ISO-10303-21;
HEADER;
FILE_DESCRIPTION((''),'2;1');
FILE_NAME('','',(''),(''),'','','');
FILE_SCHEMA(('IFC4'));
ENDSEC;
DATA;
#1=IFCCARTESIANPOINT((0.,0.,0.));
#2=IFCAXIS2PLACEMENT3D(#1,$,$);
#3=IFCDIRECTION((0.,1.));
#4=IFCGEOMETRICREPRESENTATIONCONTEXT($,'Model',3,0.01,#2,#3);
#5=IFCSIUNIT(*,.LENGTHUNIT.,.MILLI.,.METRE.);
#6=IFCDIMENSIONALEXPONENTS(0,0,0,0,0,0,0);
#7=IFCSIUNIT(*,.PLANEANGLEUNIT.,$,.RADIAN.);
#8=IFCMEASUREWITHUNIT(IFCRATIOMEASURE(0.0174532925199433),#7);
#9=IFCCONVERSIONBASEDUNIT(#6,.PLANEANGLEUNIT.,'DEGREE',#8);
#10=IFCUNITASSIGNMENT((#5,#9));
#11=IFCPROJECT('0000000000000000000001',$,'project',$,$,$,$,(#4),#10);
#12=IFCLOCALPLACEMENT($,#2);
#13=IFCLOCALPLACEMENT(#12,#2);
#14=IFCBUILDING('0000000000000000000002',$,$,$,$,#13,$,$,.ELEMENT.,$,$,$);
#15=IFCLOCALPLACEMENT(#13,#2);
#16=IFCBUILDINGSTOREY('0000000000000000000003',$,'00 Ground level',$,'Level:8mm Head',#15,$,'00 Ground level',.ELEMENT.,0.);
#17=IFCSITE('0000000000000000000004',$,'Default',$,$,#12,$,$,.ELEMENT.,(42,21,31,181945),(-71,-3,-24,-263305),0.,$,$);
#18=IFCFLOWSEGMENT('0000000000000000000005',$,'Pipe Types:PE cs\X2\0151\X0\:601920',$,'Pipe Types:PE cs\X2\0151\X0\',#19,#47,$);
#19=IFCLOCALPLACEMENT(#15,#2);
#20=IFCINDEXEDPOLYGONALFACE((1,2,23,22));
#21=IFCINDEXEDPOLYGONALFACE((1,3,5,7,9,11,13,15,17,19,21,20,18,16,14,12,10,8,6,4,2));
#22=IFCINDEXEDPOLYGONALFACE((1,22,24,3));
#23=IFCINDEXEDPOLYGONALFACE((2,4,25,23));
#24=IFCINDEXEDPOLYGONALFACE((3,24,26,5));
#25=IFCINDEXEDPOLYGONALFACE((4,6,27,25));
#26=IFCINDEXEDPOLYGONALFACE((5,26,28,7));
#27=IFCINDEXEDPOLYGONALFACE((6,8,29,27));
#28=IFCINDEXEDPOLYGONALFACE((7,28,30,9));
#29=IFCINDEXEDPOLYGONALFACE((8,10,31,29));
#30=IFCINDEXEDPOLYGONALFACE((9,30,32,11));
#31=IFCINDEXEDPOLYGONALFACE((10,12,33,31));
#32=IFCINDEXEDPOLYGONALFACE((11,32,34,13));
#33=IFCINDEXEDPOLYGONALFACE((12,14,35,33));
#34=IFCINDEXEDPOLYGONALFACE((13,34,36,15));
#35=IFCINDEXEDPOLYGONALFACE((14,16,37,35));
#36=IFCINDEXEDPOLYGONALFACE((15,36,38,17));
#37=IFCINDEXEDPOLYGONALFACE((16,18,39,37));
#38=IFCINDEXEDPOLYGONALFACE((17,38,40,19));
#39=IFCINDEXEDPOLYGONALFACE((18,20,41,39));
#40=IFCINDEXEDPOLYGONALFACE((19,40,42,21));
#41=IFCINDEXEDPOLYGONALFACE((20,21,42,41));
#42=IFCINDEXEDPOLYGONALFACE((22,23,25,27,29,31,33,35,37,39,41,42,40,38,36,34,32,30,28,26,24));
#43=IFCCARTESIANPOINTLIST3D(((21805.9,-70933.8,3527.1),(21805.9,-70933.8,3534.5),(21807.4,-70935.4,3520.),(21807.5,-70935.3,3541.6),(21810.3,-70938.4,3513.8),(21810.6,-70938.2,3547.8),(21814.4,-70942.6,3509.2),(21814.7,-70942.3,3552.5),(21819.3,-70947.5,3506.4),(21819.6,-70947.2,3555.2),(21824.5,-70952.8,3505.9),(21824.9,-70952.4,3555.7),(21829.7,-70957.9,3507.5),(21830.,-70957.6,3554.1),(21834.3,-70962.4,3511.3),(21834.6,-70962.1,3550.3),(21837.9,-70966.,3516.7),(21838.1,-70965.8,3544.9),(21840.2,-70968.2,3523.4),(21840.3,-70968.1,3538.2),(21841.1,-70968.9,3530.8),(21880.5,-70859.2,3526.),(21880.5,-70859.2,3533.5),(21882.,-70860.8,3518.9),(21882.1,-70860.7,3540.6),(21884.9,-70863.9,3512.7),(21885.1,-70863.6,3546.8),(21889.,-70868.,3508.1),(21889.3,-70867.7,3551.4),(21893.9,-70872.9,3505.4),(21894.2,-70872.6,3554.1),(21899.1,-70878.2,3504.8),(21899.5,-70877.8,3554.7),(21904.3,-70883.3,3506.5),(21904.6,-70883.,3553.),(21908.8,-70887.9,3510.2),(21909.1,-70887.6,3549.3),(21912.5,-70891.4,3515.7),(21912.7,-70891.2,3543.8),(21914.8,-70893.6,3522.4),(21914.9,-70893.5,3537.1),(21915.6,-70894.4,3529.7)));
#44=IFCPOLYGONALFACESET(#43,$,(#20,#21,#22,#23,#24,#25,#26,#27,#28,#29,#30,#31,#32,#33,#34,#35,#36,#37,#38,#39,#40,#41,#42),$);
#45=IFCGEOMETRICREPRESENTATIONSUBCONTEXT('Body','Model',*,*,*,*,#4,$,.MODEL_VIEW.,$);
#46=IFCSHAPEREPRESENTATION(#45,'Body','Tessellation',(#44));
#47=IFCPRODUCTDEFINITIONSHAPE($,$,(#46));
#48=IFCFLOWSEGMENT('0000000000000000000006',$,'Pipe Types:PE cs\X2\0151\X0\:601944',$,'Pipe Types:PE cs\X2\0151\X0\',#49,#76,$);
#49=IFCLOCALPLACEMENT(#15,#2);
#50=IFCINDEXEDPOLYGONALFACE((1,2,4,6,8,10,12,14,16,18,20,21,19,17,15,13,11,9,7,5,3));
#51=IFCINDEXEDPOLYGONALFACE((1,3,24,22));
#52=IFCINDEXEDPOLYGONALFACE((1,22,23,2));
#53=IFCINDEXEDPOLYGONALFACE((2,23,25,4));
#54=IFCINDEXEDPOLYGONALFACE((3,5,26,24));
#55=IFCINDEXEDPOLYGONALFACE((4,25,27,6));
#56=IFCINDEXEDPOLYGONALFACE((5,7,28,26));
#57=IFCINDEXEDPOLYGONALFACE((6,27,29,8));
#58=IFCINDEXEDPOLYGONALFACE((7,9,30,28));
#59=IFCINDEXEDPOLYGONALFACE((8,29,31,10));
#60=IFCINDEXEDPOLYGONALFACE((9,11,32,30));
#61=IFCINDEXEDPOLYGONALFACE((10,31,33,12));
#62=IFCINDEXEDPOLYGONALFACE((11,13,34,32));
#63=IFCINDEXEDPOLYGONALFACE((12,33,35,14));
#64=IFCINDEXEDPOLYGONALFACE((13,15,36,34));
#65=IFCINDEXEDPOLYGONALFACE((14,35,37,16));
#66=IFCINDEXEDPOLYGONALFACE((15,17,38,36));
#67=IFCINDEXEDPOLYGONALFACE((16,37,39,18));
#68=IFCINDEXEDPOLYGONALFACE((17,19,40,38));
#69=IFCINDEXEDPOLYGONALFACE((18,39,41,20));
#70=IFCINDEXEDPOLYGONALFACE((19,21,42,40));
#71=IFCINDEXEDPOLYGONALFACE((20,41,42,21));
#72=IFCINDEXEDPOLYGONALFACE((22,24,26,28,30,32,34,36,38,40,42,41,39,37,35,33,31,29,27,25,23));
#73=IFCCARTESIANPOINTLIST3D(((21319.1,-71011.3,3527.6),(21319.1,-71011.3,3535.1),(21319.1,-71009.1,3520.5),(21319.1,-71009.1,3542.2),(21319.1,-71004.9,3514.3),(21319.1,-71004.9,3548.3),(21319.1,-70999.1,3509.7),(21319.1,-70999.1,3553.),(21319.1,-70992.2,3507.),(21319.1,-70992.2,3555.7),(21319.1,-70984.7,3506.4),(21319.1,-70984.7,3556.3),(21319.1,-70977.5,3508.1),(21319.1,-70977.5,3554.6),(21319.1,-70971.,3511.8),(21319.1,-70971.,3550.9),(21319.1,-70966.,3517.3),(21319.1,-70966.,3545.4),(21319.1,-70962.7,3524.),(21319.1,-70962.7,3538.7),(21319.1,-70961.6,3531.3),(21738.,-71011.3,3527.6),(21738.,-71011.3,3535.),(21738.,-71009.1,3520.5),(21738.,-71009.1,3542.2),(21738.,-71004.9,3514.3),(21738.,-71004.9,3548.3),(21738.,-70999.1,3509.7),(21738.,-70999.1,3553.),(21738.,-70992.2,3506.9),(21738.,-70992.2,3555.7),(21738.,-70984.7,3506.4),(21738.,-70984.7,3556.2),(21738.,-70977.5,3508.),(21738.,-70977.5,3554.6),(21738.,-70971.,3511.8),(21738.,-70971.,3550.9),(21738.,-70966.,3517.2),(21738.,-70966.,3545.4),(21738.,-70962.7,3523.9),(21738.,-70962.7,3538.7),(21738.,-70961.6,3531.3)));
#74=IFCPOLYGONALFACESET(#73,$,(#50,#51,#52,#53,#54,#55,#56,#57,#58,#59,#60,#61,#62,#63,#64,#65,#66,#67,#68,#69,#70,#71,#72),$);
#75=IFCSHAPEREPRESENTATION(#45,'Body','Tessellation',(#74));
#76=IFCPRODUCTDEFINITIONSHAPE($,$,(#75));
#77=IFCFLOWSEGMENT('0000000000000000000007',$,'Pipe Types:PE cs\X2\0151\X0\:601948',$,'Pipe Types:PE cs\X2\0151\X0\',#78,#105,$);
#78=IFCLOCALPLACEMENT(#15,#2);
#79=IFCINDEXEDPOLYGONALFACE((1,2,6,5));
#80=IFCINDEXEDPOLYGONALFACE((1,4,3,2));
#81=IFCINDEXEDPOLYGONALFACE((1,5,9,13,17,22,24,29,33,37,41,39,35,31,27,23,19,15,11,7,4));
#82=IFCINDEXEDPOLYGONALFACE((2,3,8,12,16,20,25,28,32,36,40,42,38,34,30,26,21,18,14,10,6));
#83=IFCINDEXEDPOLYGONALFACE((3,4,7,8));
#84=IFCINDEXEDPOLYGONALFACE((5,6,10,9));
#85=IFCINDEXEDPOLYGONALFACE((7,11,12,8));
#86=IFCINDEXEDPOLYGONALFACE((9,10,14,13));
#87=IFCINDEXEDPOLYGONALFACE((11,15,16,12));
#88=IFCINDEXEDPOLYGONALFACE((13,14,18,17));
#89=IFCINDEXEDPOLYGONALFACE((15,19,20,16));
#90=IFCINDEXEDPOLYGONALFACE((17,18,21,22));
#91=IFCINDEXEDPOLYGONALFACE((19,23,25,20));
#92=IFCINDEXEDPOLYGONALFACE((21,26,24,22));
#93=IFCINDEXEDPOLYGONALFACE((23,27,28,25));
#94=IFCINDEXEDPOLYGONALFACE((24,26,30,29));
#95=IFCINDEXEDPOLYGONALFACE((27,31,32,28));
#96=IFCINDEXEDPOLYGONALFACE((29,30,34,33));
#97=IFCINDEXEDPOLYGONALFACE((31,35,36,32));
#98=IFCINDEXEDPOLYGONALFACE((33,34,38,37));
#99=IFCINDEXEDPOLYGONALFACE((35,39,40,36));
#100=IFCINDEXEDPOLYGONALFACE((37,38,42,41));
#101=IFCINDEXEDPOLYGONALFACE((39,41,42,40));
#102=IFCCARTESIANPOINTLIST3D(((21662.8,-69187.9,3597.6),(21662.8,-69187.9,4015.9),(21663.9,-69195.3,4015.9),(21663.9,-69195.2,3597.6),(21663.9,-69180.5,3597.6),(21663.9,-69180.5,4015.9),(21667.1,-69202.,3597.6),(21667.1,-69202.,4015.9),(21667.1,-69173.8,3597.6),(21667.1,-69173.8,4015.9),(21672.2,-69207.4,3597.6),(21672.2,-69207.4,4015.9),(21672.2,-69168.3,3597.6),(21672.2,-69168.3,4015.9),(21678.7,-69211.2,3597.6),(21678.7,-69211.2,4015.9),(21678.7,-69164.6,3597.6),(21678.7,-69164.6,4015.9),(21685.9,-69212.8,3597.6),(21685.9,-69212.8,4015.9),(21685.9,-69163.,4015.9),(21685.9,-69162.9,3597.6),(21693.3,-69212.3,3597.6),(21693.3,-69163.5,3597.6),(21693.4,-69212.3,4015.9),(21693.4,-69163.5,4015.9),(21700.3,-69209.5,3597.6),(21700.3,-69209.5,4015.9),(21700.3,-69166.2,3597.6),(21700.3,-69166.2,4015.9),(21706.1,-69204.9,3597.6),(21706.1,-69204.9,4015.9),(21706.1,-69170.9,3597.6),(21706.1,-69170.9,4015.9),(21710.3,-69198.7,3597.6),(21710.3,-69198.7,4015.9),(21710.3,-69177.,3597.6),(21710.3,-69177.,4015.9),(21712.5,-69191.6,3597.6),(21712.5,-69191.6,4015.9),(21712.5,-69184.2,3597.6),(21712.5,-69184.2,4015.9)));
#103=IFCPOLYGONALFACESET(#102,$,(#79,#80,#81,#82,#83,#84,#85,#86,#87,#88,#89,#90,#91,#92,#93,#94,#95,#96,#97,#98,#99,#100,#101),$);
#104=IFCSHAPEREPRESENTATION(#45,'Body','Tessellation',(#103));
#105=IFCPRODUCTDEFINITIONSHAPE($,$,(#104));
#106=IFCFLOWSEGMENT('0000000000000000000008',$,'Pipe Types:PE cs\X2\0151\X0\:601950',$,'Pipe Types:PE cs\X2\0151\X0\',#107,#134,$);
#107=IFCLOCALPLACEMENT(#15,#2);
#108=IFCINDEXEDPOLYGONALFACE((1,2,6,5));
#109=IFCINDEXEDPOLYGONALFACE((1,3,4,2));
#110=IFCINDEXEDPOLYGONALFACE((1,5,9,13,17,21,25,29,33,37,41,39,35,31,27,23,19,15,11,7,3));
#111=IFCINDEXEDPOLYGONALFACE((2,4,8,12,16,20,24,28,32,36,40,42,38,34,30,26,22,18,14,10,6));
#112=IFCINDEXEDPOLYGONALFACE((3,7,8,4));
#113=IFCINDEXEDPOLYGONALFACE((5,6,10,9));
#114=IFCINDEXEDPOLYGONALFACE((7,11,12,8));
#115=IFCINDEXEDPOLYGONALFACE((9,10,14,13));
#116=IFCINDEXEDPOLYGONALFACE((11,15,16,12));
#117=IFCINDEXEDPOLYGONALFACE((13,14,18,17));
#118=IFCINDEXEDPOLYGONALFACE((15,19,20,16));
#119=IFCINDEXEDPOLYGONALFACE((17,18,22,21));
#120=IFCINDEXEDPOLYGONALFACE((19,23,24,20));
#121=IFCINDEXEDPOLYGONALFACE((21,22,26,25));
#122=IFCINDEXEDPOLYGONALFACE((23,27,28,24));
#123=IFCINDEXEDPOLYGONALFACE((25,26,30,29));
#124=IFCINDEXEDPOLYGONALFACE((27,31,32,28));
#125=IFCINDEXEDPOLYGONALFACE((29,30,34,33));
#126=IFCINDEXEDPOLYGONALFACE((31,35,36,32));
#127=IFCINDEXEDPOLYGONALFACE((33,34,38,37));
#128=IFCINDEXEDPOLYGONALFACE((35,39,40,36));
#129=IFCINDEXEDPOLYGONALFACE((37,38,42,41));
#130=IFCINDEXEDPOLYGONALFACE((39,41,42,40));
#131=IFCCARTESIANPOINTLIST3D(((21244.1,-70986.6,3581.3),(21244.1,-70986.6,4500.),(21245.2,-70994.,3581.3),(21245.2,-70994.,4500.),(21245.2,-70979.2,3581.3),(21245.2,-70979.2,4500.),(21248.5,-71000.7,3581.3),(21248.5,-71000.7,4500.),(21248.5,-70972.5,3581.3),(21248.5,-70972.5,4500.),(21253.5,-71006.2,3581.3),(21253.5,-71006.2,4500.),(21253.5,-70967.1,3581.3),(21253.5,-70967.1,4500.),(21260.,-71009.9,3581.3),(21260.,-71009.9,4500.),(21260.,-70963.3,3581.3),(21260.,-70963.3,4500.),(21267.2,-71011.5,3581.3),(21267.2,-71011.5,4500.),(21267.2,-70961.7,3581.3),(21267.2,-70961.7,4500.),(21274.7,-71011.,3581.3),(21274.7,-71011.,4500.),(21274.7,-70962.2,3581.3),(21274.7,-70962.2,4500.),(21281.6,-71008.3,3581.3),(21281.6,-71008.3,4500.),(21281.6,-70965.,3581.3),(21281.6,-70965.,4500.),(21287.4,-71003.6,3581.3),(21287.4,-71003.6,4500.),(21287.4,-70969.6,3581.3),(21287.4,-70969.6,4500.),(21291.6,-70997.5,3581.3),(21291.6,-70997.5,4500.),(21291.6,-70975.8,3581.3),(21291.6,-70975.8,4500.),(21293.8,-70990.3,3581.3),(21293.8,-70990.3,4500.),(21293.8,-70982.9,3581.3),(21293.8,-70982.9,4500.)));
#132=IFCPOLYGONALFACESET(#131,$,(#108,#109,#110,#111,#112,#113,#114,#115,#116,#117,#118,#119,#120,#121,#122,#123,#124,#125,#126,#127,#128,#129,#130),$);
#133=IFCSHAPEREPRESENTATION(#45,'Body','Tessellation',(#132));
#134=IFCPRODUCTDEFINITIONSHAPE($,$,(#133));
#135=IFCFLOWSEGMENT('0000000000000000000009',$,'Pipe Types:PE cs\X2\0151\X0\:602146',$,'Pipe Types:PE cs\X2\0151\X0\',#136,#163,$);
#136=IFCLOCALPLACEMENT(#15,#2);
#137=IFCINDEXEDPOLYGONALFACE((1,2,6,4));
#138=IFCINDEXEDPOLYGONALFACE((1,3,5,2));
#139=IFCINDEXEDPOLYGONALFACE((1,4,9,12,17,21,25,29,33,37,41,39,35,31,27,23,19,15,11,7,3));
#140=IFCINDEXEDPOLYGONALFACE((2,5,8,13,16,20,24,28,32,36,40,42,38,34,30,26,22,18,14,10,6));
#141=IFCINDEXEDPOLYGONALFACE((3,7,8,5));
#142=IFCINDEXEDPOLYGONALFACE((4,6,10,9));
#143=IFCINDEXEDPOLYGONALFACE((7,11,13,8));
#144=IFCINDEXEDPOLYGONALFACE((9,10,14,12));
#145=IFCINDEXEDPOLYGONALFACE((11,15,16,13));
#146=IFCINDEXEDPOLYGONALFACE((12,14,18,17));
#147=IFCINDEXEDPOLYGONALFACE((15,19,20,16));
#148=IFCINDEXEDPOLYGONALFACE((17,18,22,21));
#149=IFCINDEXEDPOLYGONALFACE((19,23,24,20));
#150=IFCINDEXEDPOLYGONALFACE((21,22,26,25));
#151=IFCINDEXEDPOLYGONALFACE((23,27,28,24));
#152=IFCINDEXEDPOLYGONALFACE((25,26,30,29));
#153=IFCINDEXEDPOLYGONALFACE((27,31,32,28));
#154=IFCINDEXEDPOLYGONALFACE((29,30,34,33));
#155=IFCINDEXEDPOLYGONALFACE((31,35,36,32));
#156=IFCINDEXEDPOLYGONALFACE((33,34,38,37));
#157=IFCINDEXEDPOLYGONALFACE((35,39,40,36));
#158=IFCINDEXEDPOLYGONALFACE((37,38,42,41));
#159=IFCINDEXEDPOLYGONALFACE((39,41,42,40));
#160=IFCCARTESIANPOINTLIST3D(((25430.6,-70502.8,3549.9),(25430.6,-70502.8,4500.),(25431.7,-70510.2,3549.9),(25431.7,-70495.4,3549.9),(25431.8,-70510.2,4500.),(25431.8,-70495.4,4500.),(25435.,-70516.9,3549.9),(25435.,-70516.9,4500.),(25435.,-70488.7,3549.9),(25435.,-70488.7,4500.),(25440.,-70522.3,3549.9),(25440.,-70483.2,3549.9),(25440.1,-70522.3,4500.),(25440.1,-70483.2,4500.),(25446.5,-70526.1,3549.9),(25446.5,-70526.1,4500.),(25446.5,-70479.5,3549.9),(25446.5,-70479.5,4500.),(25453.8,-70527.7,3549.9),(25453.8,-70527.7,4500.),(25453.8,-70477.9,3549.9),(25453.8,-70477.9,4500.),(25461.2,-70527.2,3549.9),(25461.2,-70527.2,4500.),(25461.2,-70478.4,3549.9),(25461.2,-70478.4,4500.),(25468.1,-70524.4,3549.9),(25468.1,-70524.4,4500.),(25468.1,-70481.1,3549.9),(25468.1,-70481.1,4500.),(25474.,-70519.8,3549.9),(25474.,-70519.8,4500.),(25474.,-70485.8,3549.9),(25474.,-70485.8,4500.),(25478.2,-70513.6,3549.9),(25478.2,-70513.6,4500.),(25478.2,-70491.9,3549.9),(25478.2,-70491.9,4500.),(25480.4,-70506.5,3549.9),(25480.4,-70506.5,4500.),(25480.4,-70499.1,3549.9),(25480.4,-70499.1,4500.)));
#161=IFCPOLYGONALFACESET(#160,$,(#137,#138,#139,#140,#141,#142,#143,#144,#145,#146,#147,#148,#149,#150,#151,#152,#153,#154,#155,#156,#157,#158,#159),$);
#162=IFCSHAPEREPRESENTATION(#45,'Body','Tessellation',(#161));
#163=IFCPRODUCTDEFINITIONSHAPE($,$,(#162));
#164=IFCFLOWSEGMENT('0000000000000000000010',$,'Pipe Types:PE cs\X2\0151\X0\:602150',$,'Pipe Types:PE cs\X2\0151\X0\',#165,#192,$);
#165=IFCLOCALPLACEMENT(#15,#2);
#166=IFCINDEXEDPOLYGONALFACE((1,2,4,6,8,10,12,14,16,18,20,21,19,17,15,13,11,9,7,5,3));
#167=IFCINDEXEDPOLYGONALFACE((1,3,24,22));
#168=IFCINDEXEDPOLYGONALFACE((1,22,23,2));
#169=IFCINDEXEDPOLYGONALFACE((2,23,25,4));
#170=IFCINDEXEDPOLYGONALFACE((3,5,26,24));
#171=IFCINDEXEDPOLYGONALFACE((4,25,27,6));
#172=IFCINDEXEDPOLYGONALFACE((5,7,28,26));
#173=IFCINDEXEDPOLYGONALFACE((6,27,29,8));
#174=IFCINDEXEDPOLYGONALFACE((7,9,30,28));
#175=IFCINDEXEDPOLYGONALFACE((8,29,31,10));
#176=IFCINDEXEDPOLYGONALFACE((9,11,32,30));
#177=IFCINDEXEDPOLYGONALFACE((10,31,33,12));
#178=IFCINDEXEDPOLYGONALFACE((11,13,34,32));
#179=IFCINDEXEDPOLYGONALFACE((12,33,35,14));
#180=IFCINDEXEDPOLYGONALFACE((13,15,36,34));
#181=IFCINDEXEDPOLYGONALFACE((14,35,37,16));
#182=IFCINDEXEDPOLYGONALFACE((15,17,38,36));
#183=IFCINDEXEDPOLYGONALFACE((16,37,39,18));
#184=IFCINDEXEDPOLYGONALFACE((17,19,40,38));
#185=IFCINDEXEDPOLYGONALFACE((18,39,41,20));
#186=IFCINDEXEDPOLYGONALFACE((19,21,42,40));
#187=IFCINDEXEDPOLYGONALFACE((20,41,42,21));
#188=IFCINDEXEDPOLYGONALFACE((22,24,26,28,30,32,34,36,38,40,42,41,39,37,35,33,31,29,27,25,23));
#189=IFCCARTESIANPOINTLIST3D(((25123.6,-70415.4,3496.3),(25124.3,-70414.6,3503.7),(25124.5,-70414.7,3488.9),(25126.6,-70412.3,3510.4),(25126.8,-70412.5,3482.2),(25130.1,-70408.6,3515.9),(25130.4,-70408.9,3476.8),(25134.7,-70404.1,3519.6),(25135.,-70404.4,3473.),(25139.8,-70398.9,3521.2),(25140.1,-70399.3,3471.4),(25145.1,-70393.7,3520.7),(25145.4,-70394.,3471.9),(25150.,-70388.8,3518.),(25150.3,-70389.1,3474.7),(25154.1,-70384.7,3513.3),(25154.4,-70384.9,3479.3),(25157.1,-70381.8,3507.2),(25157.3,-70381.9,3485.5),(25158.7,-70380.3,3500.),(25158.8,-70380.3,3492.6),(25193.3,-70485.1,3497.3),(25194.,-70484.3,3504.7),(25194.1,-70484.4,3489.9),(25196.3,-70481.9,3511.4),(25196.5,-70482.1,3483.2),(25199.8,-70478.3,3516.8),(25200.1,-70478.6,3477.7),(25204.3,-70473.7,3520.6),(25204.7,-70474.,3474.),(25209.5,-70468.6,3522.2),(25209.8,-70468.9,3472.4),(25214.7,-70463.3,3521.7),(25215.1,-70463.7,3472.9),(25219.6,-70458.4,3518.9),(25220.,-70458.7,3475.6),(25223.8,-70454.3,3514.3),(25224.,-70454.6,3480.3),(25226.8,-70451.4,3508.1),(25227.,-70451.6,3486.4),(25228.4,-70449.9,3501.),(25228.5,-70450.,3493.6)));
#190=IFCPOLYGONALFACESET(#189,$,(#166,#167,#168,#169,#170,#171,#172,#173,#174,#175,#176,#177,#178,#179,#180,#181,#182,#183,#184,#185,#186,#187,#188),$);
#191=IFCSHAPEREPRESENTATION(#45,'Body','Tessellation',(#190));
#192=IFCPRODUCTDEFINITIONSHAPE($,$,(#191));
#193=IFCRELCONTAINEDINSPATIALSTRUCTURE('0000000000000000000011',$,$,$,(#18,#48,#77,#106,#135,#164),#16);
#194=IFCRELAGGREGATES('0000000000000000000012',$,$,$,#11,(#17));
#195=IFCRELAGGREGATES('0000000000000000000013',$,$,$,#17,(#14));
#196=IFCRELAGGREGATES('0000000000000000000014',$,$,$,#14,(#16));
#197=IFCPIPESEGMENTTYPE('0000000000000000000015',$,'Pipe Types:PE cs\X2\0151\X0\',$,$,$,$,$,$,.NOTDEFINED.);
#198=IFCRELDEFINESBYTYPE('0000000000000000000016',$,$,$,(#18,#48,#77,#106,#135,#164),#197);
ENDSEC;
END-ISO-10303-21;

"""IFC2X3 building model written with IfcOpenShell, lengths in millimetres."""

from ifc_helpers import new_model, entity, si_unit, converted_unit, direction, frame, frame_2d, origin, origin_2d_with_axis, place, context, subcontext, project, spatial, circle, extrude, type_object, element, save


model = new_model("IFC2X3")

# Units and contexts
model_context = context("Model", 3, precision=0.01, world=origin(), true_north=direction((0.0, 1.0)))
body_context = subcontext(model_context, "Body", "Model", "MODEL_VIEW")
ifc_project = project(units=[si_unit("LENGTHUNIT", "METRE", prefix="MILLI"), converted_unit("PLANEANGLEUNIT", "DEGREE", entity("IfcRatioMeasure", 0.0174532925199433), si_unit("PLANEANGLEUNIT", "RADIAN"), dimensions=[0, 0, 0, 0, 0, 0, 0])], contexts=[model_context])

# Site, building, storey
site_placement = place(None, origin())
site = spatial("IfcSite", under=ifc_project, at=site_placement, Name="Default", CompositionType="ELEMENT", RefLatitude=(42, 21, 31, 181945), RefLongitude=(-71, -3, -24, -263305), RefElevation=0.0)
building_placement = place(site_placement, origin())
building = spatial("IfcBuilding", under=site, at=building_placement, CompositionType="ELEMENT")
storey_placement = place(building_placement, origin())
storey = spatial("IfcBuildingStorey", under=building, at=storey_placement, Name="00 Ground level", ObjectType="Level:8mm Head", LongName="00 Ground level", CompositionType="ELEMENT", Elevation=0.0)

# Flow segments
pipe_segment_type = type_object("IfcPipeSegmentType", Name="Pipe Types:PE cső", PredefinedType="NOTDEFINED")
flow_segment_1_placement = place(storey_placement, frame((21804.1, -70970.5, 3503.2)))
element("IfcFlowSegment", 1, at=flow_segment_1_placement, inside=storey, type_object=pipe_segment_type, Name="Pipe Types:PE cső:601920", ObjectType="Pipe Types:PE cső", context=body_context, shape_type="SweptSolid", body=[
    extrude(circle(Radius=25.0, at=origin_2d_with_axis()), frame((19.3, 19.3, 27.6), z_axis=(0.707071, 0.707071, -0.01), x_axis=(0.707107, -0.707107, 0.0)), (0.0, 0.0, 1.0), 105.5),
])
flow_segment_2_placement = place(storey_placement, frame((21319.1, -71013.2, 3504.7)))
element("IfcFlowSegment", 2, at=flow_segment_2_placement, inside=storey, type_object=pipe_segment_type, Name="Pipe Types:PE cső:601944", ObjectType="Pipe Types:PE cső", context=body_context, shape_type="SweptSolid", body=[
    extrude(circle(Radius=25.0, at=origin_2d_with_axis()), frame((0.0, 26.6, 26.6), z_axis=(1.0, 0.0, -0.000085), x_axis=(0.0, 1.0, 0.0)), (0.0, 0.0, 1.0), 418.9),
])
flow_segment_3_placement = place(storey_placement, frame((21661.2, -69214.5, 3597.6)))
element("IfcFlowSegment", 3, at=flow_segment_3_placement, inside=storey, type_object=pipe_segment_type, Name="Pipe Types:PE cső:601948", ObjectType="Pipe Types:PE cső", context=body_context, shape_type="SweptSolid", body=[
    extrude(circle(Radius=25.0, at=frame_2d((0.0, 0.0), x_axis=(1.0, 0.0))), frame((26.6, 26.6, 0.0), z_axis=(0.000019, -0.000019, 1.0), x_axis=(-1.0, 0.0, 0.000019)), (0.0, 0.0, 1.0), 418.2),
])
flow_segment_4_placement = place(storey_placement, frame((21242.5, -71013.2, 3581.3)))
element("IfcFlowSegment", 4, at=flow_segment_4_placement, inside=storey, type_object=pipe_segment_type, Name="Pipe Types:PE cső:601950", ObjectType="Pipe Types:PE cső", context=body_context, shape_type="SweptSolid", body=[
    extrude(circle(Radius=25.0, at=origin_2d_with_axis()), frame((26.6, 26.6, 0.0), z_axis=(0.0, 0.000009, 1.0), x_axis=(-1.0, 0.0, 0.0)), (0.0, 0.0, 1.0), 918.7),
])
flow_segment_5_placement = place(storey_placement, frame((25429.0, -70529.4, 3549.9)))
element("IfcFlowSegment", 5, at=flow_segment_5_placement, inside=storey, type_object=pipe_segment_type, Name="Pipe Types:PE cső:602146", ObjectType="Pipe Types:PE cső", context=body_context, shape_type="SweptSolid", body=[
    extrude(circle(Radius=25.0, at=origin_2d_with_axis()), frame((26.6, 26.6, 0.0), z_axis=(0.000007, -0.000001, 1.0), x_axis=(-1.0, 0.0, 0.000007)), (0.0, 0.0, 1.0), 950.1),
])
flow_segment_6_placement = place(storey_placement, frame((25122.0, -70486.7, 3469.7)))
element("IfcFlowSegment", 6, at=flow_segment_6_placement, inside=storey, type_object=pipe_segment_type, Name="Pipe Types:PE cső:602150", ObjectType="Pipe Types:PE cső", context=body_context, shape_type="SweptSolid", body=[
    extrude(circle(Radius=25.0, at=origin_2d_with_axis()), frame((88.9, 19.3, 27.6), z_axis=(-0.707072, 0.707071, -0.009982), x_axis=(-0.707107, -0.707107, 0.0)), (0.0, 0.0, 1.0), 98.5),
])

save(model, "model.ifc")
